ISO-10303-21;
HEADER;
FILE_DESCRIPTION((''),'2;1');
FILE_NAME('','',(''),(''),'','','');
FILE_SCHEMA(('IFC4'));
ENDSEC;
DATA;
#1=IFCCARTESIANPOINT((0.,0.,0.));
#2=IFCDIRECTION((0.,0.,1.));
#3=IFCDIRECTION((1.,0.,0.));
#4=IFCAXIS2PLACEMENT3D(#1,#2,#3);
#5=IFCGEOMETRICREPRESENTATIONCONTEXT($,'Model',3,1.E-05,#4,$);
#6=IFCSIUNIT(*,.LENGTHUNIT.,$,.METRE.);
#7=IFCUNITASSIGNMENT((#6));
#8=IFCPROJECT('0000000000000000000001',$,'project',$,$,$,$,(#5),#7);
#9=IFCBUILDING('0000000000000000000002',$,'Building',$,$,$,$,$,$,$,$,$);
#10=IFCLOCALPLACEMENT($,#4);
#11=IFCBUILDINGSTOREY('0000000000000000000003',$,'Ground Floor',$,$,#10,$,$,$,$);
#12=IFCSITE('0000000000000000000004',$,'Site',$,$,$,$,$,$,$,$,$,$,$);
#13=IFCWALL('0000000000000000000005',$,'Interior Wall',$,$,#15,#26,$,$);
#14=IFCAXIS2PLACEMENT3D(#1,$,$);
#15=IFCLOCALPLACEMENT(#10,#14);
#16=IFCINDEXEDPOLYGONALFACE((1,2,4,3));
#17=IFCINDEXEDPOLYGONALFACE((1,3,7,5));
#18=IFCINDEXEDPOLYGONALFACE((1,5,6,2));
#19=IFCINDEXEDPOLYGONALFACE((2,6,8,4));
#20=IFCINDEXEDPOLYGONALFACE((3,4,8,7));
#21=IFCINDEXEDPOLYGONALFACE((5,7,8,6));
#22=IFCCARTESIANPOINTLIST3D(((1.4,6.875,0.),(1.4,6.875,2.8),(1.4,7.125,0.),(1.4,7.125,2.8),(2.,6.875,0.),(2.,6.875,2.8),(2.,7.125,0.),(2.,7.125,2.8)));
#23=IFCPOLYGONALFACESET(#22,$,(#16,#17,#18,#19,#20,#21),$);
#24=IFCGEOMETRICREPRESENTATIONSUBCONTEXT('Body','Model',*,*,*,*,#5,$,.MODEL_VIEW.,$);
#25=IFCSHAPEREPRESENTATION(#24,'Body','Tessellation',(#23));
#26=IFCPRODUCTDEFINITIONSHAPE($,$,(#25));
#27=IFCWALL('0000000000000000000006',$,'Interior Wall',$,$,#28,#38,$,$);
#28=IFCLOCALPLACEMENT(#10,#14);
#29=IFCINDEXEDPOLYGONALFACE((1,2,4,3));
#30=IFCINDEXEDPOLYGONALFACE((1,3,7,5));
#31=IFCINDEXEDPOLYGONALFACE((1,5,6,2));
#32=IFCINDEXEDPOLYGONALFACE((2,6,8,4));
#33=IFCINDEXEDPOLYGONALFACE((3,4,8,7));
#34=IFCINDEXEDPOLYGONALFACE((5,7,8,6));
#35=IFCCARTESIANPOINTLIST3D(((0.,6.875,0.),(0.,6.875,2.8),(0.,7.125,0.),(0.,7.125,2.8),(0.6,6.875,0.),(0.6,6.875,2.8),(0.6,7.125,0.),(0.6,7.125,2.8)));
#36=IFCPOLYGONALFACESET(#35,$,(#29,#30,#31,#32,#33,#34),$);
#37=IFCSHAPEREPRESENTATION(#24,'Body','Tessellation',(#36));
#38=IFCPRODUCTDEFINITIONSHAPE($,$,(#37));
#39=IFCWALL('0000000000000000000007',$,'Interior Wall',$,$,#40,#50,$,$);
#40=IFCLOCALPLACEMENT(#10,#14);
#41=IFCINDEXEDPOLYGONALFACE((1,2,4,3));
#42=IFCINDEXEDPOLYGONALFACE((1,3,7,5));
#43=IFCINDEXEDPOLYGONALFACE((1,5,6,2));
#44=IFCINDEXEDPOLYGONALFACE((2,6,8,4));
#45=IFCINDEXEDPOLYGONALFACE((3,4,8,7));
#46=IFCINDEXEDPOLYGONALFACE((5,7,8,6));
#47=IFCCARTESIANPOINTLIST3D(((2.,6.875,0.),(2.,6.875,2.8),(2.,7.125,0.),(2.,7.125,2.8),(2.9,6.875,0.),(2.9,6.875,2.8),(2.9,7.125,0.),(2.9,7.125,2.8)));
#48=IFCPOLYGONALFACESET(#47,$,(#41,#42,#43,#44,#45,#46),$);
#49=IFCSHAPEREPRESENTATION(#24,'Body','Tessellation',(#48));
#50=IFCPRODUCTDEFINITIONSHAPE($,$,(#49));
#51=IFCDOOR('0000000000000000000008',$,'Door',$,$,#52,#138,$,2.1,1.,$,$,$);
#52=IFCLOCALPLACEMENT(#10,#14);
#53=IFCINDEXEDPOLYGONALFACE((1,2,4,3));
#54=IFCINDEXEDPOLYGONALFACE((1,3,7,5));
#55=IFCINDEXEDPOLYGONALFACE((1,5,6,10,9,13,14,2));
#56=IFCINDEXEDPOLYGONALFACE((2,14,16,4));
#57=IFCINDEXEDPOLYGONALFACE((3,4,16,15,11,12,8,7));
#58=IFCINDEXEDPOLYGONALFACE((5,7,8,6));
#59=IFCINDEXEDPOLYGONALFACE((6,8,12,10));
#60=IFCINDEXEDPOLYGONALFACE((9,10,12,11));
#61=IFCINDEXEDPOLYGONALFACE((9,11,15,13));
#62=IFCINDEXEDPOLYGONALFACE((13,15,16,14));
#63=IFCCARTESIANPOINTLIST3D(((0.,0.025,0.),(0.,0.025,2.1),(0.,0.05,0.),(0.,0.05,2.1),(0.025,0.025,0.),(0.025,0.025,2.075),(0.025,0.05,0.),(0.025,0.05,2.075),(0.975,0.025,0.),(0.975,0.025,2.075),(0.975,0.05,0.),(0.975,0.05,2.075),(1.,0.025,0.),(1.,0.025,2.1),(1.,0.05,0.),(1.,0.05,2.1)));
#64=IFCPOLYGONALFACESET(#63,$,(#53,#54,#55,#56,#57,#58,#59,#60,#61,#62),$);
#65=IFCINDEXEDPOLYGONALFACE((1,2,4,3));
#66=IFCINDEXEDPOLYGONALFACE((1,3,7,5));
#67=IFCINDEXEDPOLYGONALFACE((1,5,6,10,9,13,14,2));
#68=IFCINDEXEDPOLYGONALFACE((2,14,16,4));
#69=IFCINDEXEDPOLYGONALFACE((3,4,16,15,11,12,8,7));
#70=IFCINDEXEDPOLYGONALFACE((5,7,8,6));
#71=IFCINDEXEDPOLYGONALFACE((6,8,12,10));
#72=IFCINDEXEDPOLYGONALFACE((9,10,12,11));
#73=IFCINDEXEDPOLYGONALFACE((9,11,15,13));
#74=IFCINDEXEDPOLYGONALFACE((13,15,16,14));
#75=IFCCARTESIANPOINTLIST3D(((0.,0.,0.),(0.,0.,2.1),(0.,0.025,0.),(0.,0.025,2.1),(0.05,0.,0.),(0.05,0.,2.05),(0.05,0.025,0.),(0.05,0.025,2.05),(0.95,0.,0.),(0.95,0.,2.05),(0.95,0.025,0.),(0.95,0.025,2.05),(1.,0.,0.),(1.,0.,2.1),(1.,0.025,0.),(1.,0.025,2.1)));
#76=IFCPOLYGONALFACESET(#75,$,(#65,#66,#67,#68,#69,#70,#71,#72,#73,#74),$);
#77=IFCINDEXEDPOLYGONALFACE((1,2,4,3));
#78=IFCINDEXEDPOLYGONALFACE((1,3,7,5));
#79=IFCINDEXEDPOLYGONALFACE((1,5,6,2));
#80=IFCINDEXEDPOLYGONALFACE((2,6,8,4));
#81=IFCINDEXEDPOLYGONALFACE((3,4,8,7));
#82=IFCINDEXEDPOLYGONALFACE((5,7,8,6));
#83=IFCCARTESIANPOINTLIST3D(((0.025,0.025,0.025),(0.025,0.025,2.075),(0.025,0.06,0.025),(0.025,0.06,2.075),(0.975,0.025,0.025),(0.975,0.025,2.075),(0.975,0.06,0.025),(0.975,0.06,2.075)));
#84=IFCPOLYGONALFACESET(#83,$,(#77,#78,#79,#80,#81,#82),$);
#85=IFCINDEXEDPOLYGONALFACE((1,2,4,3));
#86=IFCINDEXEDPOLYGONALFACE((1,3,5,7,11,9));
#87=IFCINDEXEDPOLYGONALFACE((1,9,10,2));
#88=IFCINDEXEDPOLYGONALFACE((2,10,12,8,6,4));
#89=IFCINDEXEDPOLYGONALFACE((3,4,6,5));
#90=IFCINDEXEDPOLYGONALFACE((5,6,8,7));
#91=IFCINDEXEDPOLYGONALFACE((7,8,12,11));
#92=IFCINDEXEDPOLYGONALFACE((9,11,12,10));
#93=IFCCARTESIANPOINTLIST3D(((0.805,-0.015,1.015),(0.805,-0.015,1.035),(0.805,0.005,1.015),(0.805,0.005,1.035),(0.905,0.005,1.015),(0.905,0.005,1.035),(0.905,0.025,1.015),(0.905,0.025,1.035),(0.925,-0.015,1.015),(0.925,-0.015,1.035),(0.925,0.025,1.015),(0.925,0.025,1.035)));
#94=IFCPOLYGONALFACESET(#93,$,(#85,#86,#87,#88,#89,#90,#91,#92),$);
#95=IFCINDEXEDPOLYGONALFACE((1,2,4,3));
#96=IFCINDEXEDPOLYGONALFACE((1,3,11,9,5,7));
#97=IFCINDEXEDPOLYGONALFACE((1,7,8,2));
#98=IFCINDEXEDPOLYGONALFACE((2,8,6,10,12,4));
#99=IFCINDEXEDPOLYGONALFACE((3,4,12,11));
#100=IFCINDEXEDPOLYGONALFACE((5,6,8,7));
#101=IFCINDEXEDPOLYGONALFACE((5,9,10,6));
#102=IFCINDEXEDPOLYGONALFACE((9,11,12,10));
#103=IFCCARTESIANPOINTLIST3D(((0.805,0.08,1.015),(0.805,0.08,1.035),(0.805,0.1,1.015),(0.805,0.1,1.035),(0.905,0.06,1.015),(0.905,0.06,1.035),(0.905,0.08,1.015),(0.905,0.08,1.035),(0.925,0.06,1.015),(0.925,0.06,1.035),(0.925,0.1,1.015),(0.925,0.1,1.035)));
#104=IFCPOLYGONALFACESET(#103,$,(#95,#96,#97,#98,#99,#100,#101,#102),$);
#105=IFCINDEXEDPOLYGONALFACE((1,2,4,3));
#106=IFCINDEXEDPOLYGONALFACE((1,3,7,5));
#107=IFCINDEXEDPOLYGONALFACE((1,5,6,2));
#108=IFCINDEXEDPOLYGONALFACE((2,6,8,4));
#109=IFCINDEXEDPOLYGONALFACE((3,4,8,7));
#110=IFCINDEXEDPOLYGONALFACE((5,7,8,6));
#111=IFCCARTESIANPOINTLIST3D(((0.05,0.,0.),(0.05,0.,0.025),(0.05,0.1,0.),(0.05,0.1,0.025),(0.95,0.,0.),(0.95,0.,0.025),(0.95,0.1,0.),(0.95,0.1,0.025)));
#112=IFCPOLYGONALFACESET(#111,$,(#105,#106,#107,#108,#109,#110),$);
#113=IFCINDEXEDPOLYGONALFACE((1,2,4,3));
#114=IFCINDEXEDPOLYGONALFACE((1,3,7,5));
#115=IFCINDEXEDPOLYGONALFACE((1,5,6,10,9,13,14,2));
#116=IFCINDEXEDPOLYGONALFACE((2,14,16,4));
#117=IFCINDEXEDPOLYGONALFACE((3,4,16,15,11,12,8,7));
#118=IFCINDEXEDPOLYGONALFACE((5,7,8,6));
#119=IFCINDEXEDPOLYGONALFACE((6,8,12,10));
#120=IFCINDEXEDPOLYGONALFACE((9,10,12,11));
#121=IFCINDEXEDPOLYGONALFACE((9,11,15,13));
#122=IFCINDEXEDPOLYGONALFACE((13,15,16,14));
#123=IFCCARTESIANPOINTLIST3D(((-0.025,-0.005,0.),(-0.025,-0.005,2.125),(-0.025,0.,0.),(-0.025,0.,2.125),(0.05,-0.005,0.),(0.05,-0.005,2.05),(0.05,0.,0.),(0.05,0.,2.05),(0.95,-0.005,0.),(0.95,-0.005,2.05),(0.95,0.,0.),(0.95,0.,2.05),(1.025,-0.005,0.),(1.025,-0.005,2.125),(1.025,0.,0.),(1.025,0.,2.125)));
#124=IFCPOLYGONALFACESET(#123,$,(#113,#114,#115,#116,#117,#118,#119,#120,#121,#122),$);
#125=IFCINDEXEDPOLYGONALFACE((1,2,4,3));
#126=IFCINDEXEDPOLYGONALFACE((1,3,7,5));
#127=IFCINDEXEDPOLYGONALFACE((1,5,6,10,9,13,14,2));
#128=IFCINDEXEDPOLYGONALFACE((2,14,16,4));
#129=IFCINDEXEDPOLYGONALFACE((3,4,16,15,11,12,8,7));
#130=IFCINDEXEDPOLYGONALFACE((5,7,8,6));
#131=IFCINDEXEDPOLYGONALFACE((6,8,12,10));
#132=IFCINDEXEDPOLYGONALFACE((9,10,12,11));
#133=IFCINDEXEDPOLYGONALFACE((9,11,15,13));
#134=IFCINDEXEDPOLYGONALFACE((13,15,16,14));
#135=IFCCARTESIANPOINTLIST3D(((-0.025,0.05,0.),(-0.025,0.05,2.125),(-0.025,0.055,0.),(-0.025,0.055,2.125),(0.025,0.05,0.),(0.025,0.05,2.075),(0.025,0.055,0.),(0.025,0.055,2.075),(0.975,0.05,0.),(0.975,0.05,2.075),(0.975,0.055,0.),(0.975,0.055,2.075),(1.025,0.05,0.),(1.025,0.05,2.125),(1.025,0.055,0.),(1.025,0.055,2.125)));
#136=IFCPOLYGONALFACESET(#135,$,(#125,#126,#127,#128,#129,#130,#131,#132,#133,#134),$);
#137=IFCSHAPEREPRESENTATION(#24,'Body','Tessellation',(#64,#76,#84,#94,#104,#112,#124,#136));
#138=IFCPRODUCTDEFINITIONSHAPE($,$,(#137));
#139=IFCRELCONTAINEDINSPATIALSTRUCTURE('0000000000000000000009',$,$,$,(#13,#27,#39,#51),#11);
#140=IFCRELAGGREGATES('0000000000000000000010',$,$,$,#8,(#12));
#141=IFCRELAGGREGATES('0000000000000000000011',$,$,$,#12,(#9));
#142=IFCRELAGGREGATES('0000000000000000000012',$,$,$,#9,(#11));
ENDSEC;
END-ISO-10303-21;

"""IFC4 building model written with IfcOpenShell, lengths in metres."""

from ifc_helpers import new_model, si_unit, frame, origin_with_axes, place, context, subcontext, project, spatial, line, indexed_curve, outline, extrude, element, save


model = new_model("IFC4")

# Units and contexts
model_context = context("Model", 3, precision=1e-05, world=origin_with_axes())
body_context = subcontext(model_context, "Body", "Model", "MODEL_VIEW")
ifc_project = project(units=[si_unit("LENGTHUNIT", "METRE")], contexts=[model_context])

# Site, building, storey
site = spatial("IfcSite", under=ifc_project, Name="Site")
building = spatial("IfcBuilding", under=site, Name="Building")
storey_placement = place(None, origin_with_axes())
storey = spatial("IfcBuildingStorey", under=building, at=storey_placement, Name="Ground Floor")

# Walls
for number, where, z_axis, x_axis, name in (
    (1, (2.0, 7.0, 0.0), (0.0, 0.0, 1.0), (-1.0, 0.0, 0.0), "Interior Wall"),
    (2, (0.6, 7.0, 0.0), (0.0, 0.0, 1.0), (-1.0, 0.0, 0.0), "Interior Wall"),
):
    element("IfcWall", number, at=place(storey_placement, frame(where, z_axis=z_axis, x_axis=x_axis)), inside=storey, Name=name, context=body_context, shape_type="SweptSolid", body=[
        extrude(outline(indexed_curve([(0.0, 0.0), (0.0, 0.25), (0.6, 0.25), (0.6, 0.0), (0.0, 0.0)], self_intersect=False)), frame((0.0, -0.125, 0.0), z_axis=(0.0, 0.0, 1.0), x_axis=(1.0, 0.0, 0.0)), (0.0, 0.0, 1.0), 2.8),
    ])
wall_1_placement = place(storey_placement, frame((2.9, 7.0, 0.0), z_axis=(0.0, 0.0, 1.0), x_axis=(-1.0, 0.0, 0.0)))
element("IfcWall", 3, at=wall_1_placement, inside=storey, Name="Interior Wall", context=body_context, shape_type="SweptSolid", body=[
    extrude(outline(indexed_curve([(0.0, 0.0), (0.0, 0.25), (0.9, 0.25), (0.9, 0.0), (0.0, 0.0)], self_intersect=False)), frame((0.0, -0.125, 0.0), z_axis=(0.0, 0.0, 1.0), x_axis=(1.0, 0.0, 0.0)), (0.0, 0.0, 1.0), 2.8),
])

# Door
door_1_placement = place(storey_placement, origin_with_axes())
element("IfcDoor", 4, at=door_1_placement, inside=storey, Name="Door", OverallHeight=2.1, OverallWidth=1.0, context=body_context, shape_type="SweptSolid", body=[
    extrude(outline(indexed_curve([(0.0, 0.0), (0.0, 2.1), (1.0, 2.1), (1.0, 0.0), (0.975, 0.0), (0.975, 2.075), (0.025, 2.075), (0.025, 0.0)], segments=[line(1, 2, 3, 4, 5, 6, 7, 8, 1)])), frame((0.0, 0.025, 0.0), z_axis=(0.0, -1.0, 0.0), x_axis=(1.0, 0.0, 0.0)), (0.0, 0.0, -1.0), 0.025),
    extrude(outline(indexed_curve([(0.0, 0.0), (0.0, 2.1), (1.0, 2.1), (1.0, 0.0), (0.95, 0.0), (0.95, 2.05), (0.05, 2.05), (0.05, 0.0)], segments=[line(1, 2, 3, 4, 5, 6, 7, 8, 1)])), frame((0.0, 0.0, 0.0), z_axis=(0.0, -1.0, 0.0), x_axis=(1.0, 0.0, 0.0)), (0.0, 0.0, -1.0), 0.025),
    extrude(outline(indexed_curve([(0.0, 0.0), (0.95, 0.0), (0.95, 0.035), (0.0, 0.035)], segments=[line(1, 2, 3, 4, 1)])), frame((0.025, 0.025, 0.025), z_axis=(0.0, 0.0, 1.0), x_axis=(1.0, 0.0, 0.0)), (0.0, 0.0, 1.0), 2.05),
    extrude(outline(indexed_curve([(0.0, 0.0), (0.0, -0.04), (-0.12, -0.04), (-0.12, -0.02), (-0.02, -0.02), (-0.02, 0.0)], segments=[line(1, 2, 3, 4, 5, 6, 1)])), frame((0.925, 0.025, 1.015), z_axis=(0.0, 0.0, 1.0), x_axis=(1.0, 0.0, 0.0)), (0.0, 0.0, 1.0), 0.02),
    extrude(outline(indexed_curve([(0.0, 0.0), (0.0, 0.04), (-0.12, 0.04), (-0.12, 0.02), (-0.02, 0.02), (-0.02, 0.0)], segments=[line(1, 2, 3, 4, 5, 6, 1)])), frame((0.925, 0.06, 1.015), z_axis=(0.0, 0.0, 1.0), x_axis=(1.0, 0.0, 0.0)), (0.0, 0.0, 1.0), 0.02),
    extrude(outline(indexed_curve([(0.0, 0.0), (0.9, 0.0), (0.9, 0.1), (0.0, 0.1)], segments=[line(1, 2, 3, 4, 1)])), frame((0.05, 0.0, 0.0), z_axis=(0.0, 0.0, 1.0), x_axis=(1.0, 0.0, 0.0)), (0.0, 0.0, 1.0), 0.025),
    extrude(outline(indexed_curve([(0.0, 0.0), (0.0, 2.125), (1.05, 2.125), (1.05, 0.0), (0.975, 0.0), (0.975, 2.05), (0.075, 2.05), (0.075, 0.0)], segments=[line(1, 2, 3, 4, 5, 6, 7, 8, 1)])), frame((-0.025, -0.005, 0.0), z_axis=(0.0, -1.0, 0.0), x_axis=(1.0, 0.0, 0.0)), (0.0, 0.0, -1.0), 0.005),
    extrude(outline(indexed_curve([(0.0, 0.0), (0.0, 2.125), (1.05, 2.125), (1.05, 0.0), (1.0, 0.0), (1.0, 2.075), (0.05, 2.075), (0.05, 0.0)], segments=[line(1, 2, 3, 4, 5, 6, 7, 8, 1)])), frame((-0.025, 0.05, 0.0), z_axis=(0.0, -1.0, 0.0), x_axis=(1.0, 0.0, 0.0)), (0.0, 0.0, -1.0), 0.005),
])

save(model, "model.ifc")
